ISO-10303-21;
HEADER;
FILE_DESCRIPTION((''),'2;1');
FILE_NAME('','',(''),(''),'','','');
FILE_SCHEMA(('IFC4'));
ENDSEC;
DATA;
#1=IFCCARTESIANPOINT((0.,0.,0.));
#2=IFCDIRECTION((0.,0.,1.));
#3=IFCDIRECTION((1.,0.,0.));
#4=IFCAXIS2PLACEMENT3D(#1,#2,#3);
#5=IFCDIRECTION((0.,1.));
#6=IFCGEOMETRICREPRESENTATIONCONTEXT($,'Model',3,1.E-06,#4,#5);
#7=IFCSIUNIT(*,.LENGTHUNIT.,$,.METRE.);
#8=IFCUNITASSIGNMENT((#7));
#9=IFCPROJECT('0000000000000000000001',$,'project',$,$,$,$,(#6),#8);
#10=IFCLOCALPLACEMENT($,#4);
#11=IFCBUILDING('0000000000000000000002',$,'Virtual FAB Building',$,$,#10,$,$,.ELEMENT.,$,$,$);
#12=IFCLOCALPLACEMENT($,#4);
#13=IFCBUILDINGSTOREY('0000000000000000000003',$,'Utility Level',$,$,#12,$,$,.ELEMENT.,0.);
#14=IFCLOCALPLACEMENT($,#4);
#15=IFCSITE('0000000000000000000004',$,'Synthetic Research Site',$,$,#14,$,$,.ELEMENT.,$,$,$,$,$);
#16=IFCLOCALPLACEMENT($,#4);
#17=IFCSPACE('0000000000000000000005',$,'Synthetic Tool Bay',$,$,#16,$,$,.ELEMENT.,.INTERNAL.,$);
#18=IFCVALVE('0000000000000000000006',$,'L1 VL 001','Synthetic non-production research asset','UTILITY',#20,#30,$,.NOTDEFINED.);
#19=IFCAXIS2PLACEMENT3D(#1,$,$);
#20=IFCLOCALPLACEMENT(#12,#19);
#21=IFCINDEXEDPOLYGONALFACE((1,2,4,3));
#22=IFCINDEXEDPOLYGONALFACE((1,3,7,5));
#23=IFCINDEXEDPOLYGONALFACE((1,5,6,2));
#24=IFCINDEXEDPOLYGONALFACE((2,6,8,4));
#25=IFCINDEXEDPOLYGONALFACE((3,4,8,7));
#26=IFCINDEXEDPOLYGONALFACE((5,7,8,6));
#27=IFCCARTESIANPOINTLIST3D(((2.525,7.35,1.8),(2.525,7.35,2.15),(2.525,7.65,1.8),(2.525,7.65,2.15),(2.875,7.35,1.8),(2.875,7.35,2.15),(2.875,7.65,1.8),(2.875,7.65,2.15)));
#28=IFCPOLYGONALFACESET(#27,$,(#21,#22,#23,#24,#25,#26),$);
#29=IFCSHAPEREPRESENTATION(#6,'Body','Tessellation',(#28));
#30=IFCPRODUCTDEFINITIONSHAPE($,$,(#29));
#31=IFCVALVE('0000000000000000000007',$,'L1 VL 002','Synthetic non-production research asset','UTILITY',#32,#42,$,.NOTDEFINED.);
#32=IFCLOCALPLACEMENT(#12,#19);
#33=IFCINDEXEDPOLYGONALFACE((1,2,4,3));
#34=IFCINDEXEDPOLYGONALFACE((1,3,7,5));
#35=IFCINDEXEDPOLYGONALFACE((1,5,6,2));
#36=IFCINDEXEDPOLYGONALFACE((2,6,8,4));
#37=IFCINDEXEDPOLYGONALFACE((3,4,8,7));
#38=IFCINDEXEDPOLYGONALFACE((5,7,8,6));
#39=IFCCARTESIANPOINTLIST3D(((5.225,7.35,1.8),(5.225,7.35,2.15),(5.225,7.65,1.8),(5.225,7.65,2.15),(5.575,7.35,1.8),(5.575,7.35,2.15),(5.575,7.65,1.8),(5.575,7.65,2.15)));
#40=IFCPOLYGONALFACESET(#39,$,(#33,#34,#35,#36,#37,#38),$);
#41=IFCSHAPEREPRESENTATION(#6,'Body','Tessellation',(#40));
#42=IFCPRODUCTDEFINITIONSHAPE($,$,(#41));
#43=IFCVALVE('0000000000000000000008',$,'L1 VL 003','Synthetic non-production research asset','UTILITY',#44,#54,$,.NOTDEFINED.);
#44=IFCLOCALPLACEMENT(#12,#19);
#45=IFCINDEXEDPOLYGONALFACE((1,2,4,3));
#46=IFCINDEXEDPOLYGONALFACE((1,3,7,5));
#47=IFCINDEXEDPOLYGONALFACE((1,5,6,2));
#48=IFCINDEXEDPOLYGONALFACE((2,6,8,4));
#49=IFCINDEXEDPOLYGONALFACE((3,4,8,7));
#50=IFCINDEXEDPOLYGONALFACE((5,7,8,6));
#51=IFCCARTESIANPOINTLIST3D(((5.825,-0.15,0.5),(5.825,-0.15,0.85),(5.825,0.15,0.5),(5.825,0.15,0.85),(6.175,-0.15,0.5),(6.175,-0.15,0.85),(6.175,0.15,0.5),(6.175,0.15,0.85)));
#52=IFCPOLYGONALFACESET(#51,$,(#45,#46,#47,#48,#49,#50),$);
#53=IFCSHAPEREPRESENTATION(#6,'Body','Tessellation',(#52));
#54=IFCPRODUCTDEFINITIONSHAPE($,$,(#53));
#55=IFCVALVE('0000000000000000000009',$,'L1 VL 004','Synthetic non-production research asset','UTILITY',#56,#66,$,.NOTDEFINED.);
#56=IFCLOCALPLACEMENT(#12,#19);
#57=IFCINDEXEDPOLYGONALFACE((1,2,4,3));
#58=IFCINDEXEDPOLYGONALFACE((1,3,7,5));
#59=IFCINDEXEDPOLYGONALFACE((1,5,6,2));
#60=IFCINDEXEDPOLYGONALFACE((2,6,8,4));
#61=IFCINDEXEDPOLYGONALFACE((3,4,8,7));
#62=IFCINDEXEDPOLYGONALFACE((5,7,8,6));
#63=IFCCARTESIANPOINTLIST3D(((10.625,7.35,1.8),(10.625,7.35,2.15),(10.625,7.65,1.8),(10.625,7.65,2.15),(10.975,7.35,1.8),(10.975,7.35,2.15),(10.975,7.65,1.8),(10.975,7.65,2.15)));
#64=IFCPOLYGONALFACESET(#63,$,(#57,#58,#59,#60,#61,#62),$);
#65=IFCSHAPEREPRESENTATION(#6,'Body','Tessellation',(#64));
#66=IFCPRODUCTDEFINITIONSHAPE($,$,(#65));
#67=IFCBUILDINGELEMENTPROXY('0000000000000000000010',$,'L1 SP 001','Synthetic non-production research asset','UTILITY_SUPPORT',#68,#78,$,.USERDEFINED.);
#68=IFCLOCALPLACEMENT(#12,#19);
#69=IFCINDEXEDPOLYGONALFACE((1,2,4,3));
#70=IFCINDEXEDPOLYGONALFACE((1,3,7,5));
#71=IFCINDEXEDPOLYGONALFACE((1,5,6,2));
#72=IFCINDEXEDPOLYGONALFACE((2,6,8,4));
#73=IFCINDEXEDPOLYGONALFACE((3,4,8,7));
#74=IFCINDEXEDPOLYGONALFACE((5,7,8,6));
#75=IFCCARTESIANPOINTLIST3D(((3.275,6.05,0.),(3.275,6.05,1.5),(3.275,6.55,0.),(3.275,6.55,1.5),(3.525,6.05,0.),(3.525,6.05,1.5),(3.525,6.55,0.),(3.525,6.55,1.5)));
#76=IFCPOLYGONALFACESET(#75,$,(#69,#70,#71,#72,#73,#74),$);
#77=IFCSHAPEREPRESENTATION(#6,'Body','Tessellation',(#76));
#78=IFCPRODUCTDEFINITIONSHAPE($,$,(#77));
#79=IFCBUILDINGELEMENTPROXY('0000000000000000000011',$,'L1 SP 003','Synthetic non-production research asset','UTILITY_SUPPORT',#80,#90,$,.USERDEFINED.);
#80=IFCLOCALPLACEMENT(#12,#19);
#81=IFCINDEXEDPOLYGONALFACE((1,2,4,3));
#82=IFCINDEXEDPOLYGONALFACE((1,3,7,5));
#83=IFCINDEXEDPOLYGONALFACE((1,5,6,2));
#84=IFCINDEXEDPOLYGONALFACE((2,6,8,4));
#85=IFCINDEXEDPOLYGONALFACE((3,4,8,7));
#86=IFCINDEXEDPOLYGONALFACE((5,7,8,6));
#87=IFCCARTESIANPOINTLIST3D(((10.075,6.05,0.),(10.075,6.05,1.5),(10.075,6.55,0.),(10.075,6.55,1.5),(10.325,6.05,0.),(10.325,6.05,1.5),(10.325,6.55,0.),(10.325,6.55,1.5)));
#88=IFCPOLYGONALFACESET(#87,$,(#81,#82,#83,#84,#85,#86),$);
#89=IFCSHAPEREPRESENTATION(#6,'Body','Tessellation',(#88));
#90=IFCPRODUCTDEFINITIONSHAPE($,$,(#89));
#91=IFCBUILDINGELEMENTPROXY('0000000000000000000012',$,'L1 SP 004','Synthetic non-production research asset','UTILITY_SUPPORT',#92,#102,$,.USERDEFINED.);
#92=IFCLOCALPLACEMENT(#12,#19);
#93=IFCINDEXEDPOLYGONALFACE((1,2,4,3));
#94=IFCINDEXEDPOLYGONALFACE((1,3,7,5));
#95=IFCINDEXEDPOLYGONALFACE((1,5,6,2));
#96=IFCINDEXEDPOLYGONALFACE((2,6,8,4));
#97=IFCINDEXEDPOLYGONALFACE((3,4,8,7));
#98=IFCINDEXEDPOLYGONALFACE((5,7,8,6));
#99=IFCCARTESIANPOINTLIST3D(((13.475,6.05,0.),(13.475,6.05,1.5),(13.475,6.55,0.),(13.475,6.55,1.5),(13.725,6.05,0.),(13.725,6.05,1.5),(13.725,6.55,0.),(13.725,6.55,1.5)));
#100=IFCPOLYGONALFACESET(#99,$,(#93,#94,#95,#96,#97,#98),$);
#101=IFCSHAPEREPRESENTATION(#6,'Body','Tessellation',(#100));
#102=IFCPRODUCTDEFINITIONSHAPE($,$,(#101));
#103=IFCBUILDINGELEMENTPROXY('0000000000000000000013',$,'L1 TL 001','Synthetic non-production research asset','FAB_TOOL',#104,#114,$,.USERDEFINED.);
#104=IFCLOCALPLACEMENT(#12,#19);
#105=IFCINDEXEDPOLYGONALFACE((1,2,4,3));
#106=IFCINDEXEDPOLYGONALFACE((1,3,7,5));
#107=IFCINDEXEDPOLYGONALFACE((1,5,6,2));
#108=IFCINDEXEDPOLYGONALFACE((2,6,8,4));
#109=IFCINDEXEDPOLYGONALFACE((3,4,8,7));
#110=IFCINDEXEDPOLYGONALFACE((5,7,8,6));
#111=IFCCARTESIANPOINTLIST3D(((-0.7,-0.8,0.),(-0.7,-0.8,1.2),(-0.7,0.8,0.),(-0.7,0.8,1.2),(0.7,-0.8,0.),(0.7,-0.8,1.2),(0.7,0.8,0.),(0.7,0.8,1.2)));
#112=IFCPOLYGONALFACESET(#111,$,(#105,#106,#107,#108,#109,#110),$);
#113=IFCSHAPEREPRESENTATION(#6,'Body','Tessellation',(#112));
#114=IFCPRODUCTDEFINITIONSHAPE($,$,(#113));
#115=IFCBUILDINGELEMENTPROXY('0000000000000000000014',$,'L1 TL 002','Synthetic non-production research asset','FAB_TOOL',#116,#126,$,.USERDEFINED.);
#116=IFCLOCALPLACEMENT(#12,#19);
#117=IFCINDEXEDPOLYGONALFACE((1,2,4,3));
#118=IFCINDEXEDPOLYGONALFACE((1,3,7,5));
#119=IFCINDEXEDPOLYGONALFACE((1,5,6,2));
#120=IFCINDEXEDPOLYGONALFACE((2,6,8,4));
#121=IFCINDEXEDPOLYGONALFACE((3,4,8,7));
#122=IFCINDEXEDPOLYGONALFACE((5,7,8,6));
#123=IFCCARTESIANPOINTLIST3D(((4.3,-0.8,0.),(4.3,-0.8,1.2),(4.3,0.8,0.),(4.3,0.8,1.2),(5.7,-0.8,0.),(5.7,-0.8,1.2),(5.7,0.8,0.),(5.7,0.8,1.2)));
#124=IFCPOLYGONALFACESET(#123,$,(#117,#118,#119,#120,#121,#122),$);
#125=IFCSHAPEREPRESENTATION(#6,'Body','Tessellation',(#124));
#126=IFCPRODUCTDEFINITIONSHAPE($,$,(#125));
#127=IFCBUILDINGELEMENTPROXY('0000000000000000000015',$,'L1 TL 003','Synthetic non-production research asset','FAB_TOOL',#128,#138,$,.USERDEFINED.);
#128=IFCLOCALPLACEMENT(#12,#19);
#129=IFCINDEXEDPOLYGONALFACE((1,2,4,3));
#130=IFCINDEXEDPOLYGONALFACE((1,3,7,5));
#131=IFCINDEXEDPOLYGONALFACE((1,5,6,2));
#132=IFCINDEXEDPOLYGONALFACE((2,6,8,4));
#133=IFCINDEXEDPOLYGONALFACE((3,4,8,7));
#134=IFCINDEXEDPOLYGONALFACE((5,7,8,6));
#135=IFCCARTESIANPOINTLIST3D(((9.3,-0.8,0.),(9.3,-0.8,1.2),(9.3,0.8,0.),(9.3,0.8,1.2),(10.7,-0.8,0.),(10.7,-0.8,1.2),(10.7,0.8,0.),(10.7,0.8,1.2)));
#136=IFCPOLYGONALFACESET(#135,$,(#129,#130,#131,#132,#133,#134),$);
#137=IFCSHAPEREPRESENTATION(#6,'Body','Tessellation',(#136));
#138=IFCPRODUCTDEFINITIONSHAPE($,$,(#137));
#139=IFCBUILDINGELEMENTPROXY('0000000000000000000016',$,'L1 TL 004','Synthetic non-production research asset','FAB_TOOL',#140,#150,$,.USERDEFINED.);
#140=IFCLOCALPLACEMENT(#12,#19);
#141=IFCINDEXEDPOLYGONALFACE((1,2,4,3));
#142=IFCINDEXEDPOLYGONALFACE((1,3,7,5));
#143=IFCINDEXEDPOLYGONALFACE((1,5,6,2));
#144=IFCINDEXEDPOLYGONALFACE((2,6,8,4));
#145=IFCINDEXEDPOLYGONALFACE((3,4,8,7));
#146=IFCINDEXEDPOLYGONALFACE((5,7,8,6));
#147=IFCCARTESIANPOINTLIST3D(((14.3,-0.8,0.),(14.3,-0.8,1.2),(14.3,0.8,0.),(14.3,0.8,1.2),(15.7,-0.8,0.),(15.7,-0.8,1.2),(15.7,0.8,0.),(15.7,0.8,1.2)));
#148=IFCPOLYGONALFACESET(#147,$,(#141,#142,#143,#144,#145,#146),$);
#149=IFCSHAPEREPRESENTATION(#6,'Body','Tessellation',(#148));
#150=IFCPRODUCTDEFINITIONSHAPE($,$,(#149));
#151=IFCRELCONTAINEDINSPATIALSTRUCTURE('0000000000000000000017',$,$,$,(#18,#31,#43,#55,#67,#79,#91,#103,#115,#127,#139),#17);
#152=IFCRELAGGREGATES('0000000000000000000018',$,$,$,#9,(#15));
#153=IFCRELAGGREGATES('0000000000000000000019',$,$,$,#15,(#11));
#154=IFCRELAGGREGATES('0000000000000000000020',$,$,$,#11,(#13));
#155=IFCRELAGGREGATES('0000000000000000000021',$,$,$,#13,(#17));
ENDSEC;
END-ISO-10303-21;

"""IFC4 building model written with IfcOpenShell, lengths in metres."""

from ifc_helpers import new_model, si_unit, direction, frame, origin_with_axes, origin_2d_with_axis, place, context, project, spatial, rectangle, extrude, element, save


model = new_model("IFC4")

# Units and contexts
model_context = context("Model", 3, precision=1e-06, world=origin_with_axes(), true_north=direction((0.0, 1.0)))
ifc_project = project(units=[si_unit("LENGTHUNIT", "METRE")], contexts=[model_context])

# Site, building, storey, space
site_placement = place(None, origin_with_axes())
site = spatial("IfcSite", under=ifc_project, at=site_placement, Name="Synthetic Research Site", CompositionType="ELEMENT")
building_placement = place(None, origin_with_axes())
building = spatial("IfcBuilding", under=site, at=building_placement, Name="Virtual FAB Building", CompositionType="ELEMENT")
storey_placement = place(None, origin_with_axes())
storey = spatial("IfcBuildingStorey", under=building, at=storey_placement, Name="Utility Level", CompositionType="ELEMENT", Elevation=0.0)
space_placement = place(None, origin_with_axes())
space = spatial("IfcSpace", under=storey, at=space_placement, Name="Synthetic Tool Bay", CompositionType="ELEMENT", PredefinedType="INTERNAL")

# Valves
for number, where, z_axis, x_axis, name in (
    (1, (2.7, 7.5, 1.8), (0.0, 0.0, 1.0), (1.0, 0.0, 0.0), "L1 VL 001"),
    (2, (5.4, 7.5, 1.8), (0.0, 0.0, 1.0), (1.0, 0.0, 0.0), "L1 VL 002"),
    (3, (6.0, 0.0, 0.5), (0.0, 0.0, 1.0), (1.0, 0.0, 0.0), "L1 VL 003"),
    (4, (10.8, 7.5, 1.8), (0.0, 0.0, 1.0), (1.0, 0.0, 0.0), "L1 VL 004"),
):
    element("IfcValve", number, at=place(None, frame(where, z_axis=z_axis, x_axis=x_axis)), inside=space, Name=name, Description="Synthetic non-production research asset", ObjectType="UTILITY", PredefinedType="NOTDEFINED", context=model_context, shape_type="SweptSolid", body=[
        extrude(rectangle(XDim=0.35, YDim=0.3, at=origin_2d_with_axis()), origin_with_axes(), (0.0, 0.0, 1.0), 0.35),
    ])

# Building element proxies
for number, where, z_axis, x_axis, name in (
    (5, (3.4, 6.3, 0.0), (0.0, 0.0, 1.0), (1.0, 0.0, 0.0), "L1 SP 001"),
    (6, (10.2, 6.3, 0.0), (0.0, 0.0, 1.0), (1.0, 0.0, 0.0), "L1 SP 003"),
    (7, (13.6, 6.3, 0.0), (0.0, 0.0, 1.0), (1.0, 0.0, 0.0), "L1 SP 004"),
):
    element("IfcBuildingElementProxy", number, at=place(None, frame(where, z_axis=z_axis, x_axis=x_axis)), inside=space, Name=name, Description="Synthetic non-production research asset", ObjectType="UTILITY_SUPPORT", PredefinedType="USERDEFINED", context=model_context, shape_type="SweptSolid", body=[
        extrude(rectangle(XDim=0.25, YDim=0.5, at=origin_2d_with_axis()), origin_with_axes(), (0.0, 0.0, 1.0), 1.5),
    ])
for number, where, z_axis, x_axis, name in (
    (8, (0.0, 0.0, 0.0), (0.0, 0.0, 1.0), (1.0, 0.0, 0.0), "L1 TL 001"),
    (9, (5.0, 0.0, 0.0), (0.0, 0.0, 1.0), (1.0, 0.0, 0.0), "L1 TL 002"),
    (10, (10.0, 0.0, 0.0), (0.0, 0.0, 1.0), (1.0, 0.0, 0.0), "L1 TL 003"),
    (11, (15.0, 0.0, 0.0), (0.0, 0.0, 1.0), (1.0, 0.0, 0.0), "L1 TL 004"),
):
    element("IfcBuildingElementProxy", number, at=place(None, frame(where, z_axis=z_axis, x_axis=x_axis)), inside=space, Name=name, Description="Synthetic non-production research asset", ObjectType="FAB_TOOL", PredefinedType="USERDEFINED", context=model_context, shape_type="SweptSolid", body=[
        extrude(rectangle(XDim=1.4, YDim=1.6, at=origin_2d_with_axis()), origin_with_axes(), (0.0, 0.0, 1.0), 1.2),
    ])

save(model, "model.ifc")
